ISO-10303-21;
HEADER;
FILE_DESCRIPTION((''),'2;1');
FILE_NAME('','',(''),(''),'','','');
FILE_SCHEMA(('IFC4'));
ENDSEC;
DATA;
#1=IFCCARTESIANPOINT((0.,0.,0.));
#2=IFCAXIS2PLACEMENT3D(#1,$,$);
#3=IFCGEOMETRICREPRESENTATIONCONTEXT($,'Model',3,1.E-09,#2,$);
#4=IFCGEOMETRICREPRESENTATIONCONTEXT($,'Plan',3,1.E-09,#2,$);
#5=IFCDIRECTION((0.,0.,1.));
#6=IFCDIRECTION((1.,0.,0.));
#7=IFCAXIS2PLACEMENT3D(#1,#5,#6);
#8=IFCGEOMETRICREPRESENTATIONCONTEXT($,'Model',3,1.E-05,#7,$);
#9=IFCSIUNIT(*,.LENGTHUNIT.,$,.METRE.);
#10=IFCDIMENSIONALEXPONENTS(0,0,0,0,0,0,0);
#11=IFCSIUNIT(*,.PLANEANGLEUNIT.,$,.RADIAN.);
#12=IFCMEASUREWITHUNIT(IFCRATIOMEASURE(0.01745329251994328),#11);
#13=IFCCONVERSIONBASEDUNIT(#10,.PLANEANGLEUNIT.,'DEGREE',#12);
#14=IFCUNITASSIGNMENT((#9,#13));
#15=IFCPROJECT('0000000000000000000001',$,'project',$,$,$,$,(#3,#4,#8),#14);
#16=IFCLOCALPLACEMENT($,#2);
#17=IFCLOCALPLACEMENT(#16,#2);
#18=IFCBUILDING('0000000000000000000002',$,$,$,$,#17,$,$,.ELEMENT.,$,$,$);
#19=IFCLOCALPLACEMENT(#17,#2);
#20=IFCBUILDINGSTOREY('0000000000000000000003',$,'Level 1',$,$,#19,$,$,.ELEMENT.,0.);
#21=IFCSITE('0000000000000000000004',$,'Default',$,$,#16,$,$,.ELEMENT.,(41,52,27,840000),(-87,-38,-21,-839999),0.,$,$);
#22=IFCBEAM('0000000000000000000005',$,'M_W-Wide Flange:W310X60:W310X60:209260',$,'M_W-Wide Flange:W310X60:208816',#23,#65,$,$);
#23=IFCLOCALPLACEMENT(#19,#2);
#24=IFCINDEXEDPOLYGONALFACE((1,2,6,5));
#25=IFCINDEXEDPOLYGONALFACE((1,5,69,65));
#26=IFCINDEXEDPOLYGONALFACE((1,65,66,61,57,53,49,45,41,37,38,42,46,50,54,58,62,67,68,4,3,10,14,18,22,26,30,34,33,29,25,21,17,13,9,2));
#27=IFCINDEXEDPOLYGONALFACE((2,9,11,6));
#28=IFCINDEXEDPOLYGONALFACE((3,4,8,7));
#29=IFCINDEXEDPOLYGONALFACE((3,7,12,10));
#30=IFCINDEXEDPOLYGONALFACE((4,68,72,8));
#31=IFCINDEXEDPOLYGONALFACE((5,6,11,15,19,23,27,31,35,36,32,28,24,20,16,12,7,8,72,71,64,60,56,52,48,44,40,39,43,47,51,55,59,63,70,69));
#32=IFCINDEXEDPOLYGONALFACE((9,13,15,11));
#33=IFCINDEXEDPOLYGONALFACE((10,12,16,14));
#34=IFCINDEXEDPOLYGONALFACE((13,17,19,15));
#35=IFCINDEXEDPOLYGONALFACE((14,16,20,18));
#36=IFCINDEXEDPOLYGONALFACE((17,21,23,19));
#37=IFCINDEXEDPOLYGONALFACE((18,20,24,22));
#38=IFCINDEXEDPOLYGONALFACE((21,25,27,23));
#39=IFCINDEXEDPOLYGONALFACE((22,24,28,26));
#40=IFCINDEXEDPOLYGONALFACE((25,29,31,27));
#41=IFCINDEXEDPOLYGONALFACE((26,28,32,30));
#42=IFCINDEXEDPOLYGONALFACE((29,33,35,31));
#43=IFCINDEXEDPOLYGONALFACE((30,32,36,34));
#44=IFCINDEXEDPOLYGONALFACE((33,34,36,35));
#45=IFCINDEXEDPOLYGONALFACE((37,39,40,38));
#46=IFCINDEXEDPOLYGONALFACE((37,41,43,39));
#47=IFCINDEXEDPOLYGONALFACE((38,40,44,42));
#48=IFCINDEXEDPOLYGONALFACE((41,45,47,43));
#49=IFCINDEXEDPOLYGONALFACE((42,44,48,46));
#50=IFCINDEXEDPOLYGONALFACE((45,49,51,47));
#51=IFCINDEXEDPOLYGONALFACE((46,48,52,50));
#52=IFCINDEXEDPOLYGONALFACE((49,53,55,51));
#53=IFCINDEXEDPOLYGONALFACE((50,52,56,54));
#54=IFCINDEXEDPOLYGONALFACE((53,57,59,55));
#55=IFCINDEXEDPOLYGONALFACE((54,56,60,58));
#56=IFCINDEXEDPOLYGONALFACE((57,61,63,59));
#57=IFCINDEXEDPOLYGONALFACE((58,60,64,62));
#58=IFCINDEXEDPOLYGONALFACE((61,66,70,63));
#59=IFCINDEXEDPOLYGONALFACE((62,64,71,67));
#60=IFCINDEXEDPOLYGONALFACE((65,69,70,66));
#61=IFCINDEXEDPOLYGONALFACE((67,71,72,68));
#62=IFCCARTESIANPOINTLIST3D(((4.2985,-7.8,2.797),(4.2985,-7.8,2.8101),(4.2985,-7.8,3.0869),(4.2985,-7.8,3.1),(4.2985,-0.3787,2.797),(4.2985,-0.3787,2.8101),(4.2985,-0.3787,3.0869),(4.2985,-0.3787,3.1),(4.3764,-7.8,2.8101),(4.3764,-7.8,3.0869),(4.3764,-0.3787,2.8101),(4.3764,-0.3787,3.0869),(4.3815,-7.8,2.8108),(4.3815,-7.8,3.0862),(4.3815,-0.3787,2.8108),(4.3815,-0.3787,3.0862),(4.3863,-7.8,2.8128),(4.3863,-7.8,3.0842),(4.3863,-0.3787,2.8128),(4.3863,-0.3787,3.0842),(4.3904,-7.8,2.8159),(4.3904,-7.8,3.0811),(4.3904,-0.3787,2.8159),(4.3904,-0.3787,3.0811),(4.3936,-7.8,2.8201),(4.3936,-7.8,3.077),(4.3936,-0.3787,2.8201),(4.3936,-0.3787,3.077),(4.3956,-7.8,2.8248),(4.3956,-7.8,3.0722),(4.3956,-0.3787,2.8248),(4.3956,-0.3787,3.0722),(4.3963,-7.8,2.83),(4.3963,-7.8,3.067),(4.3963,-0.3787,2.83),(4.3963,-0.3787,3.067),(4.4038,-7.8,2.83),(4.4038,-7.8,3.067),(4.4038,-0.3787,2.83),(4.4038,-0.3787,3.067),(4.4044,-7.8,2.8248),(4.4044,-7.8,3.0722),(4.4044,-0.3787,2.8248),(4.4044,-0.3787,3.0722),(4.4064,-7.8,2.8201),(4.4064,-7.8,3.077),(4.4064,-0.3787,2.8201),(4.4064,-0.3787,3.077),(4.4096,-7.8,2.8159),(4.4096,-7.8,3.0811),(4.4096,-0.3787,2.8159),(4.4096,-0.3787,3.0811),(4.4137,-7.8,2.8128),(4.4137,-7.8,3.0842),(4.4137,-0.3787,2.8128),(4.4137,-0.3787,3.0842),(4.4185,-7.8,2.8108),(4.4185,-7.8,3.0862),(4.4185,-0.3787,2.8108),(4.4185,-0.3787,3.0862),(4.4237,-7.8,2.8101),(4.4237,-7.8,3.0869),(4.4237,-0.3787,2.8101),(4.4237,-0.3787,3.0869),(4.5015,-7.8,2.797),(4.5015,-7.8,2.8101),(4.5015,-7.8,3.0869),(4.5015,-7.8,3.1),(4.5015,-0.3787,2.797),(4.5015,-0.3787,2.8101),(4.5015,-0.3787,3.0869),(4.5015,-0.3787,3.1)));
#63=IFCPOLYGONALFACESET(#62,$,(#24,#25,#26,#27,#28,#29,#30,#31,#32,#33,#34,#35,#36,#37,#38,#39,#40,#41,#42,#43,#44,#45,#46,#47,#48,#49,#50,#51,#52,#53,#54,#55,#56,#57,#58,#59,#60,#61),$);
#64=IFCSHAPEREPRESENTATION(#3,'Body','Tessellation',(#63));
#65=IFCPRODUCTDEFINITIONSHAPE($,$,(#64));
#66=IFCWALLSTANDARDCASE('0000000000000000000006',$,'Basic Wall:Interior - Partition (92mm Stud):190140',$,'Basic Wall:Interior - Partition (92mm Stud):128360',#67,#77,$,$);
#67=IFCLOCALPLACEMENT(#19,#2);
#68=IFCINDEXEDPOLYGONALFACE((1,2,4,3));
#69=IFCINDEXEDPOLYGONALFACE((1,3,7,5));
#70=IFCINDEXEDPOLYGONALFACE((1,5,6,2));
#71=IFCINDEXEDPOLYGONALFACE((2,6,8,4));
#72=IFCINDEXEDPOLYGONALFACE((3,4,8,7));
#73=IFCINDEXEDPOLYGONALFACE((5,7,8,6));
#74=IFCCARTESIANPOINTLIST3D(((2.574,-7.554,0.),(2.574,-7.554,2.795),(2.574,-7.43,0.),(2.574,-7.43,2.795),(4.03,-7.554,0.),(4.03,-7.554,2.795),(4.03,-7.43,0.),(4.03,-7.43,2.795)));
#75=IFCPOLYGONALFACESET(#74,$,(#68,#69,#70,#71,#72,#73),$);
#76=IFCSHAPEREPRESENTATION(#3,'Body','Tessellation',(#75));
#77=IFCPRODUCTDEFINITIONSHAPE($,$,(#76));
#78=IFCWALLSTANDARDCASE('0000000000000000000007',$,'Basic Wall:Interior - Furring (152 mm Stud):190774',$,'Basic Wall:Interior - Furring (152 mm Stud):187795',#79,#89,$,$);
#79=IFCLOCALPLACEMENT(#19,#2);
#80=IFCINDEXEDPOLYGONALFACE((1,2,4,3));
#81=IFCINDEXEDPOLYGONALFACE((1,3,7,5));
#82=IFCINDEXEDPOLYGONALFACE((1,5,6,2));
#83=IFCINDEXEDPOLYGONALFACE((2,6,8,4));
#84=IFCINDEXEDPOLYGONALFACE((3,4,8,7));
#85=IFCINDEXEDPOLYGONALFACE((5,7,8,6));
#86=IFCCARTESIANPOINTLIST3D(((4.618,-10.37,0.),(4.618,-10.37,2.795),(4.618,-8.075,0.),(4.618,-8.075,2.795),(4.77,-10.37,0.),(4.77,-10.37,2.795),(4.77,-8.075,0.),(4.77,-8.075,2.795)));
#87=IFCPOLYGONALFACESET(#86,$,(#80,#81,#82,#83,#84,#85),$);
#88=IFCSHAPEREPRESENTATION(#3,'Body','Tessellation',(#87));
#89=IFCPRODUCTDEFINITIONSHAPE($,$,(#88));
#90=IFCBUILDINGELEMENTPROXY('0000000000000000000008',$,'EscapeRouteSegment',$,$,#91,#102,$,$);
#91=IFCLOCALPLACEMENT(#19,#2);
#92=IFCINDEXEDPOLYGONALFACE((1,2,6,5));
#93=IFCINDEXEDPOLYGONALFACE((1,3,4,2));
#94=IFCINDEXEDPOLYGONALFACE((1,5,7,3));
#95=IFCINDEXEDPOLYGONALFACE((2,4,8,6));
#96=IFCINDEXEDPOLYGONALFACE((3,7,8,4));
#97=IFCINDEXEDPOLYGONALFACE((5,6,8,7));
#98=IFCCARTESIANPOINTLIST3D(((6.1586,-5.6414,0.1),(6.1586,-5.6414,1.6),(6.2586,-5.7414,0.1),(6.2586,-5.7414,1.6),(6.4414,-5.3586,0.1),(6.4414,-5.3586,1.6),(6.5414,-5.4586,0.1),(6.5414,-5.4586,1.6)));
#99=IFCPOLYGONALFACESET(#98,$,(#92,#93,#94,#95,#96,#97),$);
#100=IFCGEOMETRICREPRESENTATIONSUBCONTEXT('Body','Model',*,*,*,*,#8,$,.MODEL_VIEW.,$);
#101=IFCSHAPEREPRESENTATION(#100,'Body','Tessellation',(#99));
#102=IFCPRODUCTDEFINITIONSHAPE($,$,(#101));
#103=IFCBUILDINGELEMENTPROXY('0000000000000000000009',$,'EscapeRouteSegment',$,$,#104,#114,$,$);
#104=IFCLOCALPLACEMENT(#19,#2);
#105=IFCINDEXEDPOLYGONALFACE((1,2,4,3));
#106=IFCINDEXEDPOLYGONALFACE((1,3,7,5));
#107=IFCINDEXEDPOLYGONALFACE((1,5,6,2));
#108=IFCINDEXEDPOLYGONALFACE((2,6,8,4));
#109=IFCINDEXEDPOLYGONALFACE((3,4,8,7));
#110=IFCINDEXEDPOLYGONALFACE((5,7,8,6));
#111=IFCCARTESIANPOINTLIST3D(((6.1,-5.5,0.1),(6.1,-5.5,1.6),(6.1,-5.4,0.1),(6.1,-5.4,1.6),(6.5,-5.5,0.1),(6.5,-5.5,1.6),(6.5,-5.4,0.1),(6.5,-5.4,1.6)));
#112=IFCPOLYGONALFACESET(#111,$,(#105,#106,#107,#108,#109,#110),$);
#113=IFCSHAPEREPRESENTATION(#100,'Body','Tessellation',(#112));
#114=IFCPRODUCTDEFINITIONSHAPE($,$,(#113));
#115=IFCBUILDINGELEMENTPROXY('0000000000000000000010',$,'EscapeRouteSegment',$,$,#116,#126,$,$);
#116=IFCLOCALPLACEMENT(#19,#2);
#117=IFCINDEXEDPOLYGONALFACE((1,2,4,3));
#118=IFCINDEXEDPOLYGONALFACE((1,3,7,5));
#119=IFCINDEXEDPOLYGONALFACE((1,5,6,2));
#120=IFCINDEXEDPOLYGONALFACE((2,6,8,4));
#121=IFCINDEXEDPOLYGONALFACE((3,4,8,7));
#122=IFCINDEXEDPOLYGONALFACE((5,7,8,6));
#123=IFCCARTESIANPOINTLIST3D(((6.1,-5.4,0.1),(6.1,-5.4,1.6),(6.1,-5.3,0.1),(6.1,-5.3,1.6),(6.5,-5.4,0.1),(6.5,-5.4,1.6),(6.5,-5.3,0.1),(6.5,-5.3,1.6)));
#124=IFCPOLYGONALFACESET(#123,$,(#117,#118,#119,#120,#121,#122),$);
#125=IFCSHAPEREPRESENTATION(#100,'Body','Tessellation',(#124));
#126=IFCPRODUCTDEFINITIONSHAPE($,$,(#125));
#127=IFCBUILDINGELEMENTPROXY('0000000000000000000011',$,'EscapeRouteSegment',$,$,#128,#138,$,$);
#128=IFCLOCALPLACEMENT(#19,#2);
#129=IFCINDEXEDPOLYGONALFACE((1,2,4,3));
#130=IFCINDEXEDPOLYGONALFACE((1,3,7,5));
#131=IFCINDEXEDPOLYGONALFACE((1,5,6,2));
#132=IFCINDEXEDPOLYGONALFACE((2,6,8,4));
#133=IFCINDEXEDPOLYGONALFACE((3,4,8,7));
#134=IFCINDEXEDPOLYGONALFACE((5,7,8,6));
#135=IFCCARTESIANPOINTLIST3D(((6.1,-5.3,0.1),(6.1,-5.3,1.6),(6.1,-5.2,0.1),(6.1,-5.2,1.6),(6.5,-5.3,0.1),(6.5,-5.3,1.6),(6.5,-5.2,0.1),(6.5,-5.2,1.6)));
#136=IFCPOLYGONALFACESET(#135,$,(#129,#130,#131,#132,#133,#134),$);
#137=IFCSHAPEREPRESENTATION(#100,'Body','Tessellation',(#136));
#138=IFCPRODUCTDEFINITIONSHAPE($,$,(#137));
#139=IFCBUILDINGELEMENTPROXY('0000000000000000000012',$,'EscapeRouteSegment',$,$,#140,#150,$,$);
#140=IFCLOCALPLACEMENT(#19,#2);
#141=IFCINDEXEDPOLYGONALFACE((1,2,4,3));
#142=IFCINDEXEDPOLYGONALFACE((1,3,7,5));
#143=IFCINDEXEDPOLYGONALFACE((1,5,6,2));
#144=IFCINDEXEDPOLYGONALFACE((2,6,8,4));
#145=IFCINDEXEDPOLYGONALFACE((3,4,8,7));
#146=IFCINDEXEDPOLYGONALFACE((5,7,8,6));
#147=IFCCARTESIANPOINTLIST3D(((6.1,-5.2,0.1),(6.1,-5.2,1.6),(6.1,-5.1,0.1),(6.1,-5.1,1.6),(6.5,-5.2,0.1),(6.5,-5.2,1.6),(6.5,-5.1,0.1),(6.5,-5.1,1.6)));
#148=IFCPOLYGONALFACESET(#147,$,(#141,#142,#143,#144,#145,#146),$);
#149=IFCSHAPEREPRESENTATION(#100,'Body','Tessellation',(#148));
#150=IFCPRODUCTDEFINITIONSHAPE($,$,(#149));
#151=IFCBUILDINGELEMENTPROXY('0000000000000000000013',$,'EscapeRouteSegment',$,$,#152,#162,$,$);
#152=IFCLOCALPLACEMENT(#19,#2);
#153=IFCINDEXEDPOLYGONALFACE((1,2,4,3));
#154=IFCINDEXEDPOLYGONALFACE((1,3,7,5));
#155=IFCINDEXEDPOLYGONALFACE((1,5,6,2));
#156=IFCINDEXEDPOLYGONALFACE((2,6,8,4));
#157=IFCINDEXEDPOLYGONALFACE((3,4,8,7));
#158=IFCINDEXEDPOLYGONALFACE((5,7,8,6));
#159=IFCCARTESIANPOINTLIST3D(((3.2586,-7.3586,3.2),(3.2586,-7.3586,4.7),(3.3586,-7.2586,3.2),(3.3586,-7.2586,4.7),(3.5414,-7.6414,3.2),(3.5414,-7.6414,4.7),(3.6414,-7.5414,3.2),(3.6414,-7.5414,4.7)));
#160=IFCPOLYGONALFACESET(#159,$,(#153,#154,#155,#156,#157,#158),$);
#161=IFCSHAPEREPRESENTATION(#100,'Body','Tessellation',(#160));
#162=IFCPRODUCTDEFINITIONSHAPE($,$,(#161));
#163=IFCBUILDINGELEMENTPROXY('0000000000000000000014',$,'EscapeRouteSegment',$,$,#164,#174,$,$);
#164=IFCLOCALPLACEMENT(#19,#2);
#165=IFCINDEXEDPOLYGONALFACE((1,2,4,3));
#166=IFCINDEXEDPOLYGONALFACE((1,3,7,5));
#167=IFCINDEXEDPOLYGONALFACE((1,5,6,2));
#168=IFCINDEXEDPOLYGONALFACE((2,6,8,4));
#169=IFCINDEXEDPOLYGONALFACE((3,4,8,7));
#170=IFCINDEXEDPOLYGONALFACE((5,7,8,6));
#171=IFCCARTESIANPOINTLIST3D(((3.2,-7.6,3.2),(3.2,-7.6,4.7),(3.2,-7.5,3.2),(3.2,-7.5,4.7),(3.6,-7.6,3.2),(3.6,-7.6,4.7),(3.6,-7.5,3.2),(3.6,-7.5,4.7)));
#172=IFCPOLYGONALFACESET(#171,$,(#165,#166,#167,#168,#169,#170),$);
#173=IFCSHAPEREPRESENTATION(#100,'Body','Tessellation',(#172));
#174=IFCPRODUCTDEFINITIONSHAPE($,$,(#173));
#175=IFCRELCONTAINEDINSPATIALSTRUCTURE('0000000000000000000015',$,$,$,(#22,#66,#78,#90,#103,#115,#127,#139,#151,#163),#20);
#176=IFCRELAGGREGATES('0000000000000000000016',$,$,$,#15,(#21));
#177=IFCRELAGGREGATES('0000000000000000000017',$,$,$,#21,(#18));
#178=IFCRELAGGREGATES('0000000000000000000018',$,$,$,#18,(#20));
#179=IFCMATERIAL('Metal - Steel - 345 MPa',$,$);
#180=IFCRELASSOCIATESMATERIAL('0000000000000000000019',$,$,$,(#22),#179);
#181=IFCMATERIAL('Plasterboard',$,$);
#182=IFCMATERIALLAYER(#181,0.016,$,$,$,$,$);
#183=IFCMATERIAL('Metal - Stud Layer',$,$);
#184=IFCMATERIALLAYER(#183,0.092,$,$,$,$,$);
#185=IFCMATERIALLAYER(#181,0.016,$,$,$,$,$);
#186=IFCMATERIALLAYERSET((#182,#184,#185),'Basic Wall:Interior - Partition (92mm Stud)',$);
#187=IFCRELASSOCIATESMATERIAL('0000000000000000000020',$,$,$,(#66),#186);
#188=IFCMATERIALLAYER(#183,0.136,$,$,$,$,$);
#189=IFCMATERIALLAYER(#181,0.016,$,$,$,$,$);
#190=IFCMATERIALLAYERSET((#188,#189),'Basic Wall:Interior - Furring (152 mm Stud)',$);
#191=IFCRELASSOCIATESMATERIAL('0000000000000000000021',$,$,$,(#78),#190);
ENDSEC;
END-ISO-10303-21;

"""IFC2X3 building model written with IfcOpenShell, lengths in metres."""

from ifc_helpers import new_model, entity, si_unit, converted_unit, frame, frame_2d, origin, origin_with_axes, place, context, subcontext, project, spatial, polyline, circle_curve, parameter, trimmed, segment, composite_curve, rectangle, outline, extrude, material, layer, layer_set, layer_usage, element, save


model = new_model("IFC2X3")

# Units and contexts
model_context_1 = context("Model", 3, precision=1e-09, world=origin())
plan_context = context("Plan", 3, precision=1e-09, world=origin())
model_context_2 = context("Model", 3, precision=1e-05, world=origin_with_axes())
body_context = subcontext(model_context_2, "Body", "Model", "MODEL_VIEW")
ifc_project = project(units=[si_unit("LENGTHUNIT", "METRE"), converted_unit("PLANEANGLEUNIT", "DEGREE", entity("IfcRatioMeasure", 0.01745329251994328), si_unit("PLANEANGLEUNIT", "RADIAN"), dimensions=[0, 0, 0, 0, 0, 0, 0])], contexts=[model_context_1, plan_context, model_context_2])

# Site, building, storey
site_placement = place(None, origin())
site = spatial("IfcSite", under=ifc_project, at=site_placement, Name="Default", CompositionType="ELEMENT", RefLatitude=(41, 52, 27, 840000), RefLongitude=(-87, -38, -21, -839999), RefElevation=0.0)
building_placement = place(site_placement, origin())
building = spatial("IfcBuilding", under=site, at=building_placement, CompositionType="ELEMENT")
storey_placement = place(building_placement, origin())
storey = spatial("IfcBuildingStorey", under=building, at=storey_placement, Name="Level 1", CompositionType="ELEMENT", Elevation=0.0)

# Beam
ifc_material_1 = material(Name="Metal - Steel - 345 MPa")
beam_placement = place(storey_placement, frame((4.4, -7.8, 3.1)))
element("IfcBeam", 1, at=beam_placement, inside=storey, material=ifc_material_1, Name="M_W-Wide Flange:W310X60:W310X60:209260", ObjectType="M_W-Wide Flange:W310X60:208816", context=model_context_1, shape_type="SweptSolid", body=[
    extrude(outline(composite_curve([segment(polyline([(-0.1015, -0.1384), (-0.1015, -0.1515)]), True, "CONTINUOUS"), segment(polyline([(-0.1015, -0.1515), (0.1015, -0.1515)]), True, "CONTINUOUS"), segment(polyline([(0.1015, -0.1515), (0.1015, -0.1384)]), True, "CONTINUOUS"), segment(polyline([(0.1015, -0.1384), (0.0236, -0.1384)]), True, "CONTINUOUS"), segment(trimmed(circle_curve(frame_2d((0.0236, -0.1185), x_axis=(1.0, 0.0)), 0.0199), [parameter(180.0)], [parameter(270.0)], True, "PARAMETER"), False, "CONTINUOUS"), segment(polyline([(0.0037, -0.1185), (0.0037, 0.1185)]), True, "CONTINUOUS"), segment(trimmed(circle_curve(frame_2d((0.0236, 0.1185), x_axis=(1.0, 0.0)), 0.0199), [parameter(90.0)], [parameter(180.0)], True, "PARAMETER"), False, "CONTINUOUS"), segment(polyline([(0.0236, 0.1384), (0.1015, 0.1384)]), True, "CONTINUOUS"), segment(polyline([(0.1015, 0.1384), (0.1015, 0.1515)]), True, "CONTINUOUS"), segment(polyline([(0.1015, 0.1515), (-0.1015, 0.1515)]), True, "CONTINUOUS"), segment(polyline([(-0.1015, 0.1515), (-0.1015, 0.1384)]), True, "CONTINUOUS"), segment(polyline([(-0.1015, 0.1384), (-0.0237, 0.1384)]), True, "CONTINUOUS"), segment(trimmed(circle_curve(frame_2d((-0.0237, 0.1185), x_axis=(1.0, 0.0)), 0.0199), [parameter(360.0)], [parameter(90.0)], True, "PARAMETER"), False, "CONTINUOUS"), segment(polyline([(-0.0038, 0.1185), (-0.0038, -0.1185)]), True, "CONTINUOUS"), segment(trimmed(circle_curve(frame_2d((-0.0237, -0.1185), x_axis=(1.0, 0.0)), 0.0199), [parameter(270.0)], [parameter(0.0)], True, "PARAMETER"), False, "CONTINUOUS"), segment(polyline([(-0.0237, -0.1384), (-0.1015, -0.1384)]), True, "CONTINUOUS")], self_intersect=False)), frame((0.0, 0.0, -0.1515), z_axis=(0.0, -1.0, 0.0), x_axis=(1.0, 0.0, 0.0)), (0.0, 0.0, -1.0), 7.4213),
])

# Walls
ifc_material_2 = material(Name="Plasterboard")
ifc_layer_1 = layer(ifc_material_2, 0.016)
ifc_material_3 = material(Name="Metal - Stud Layer")
ifc_layer_2 = layer(ifc_material_3, 0.092)
ifc_layer_3 = layer(ifc_material_2, 0.016)
ifc_layer_set_1 = layer_set([ifc_layer_1, ifc_layer_2, ifc_layer_3], Name="Basic Wall:Interior - Partition (92mm Stud)")
ifc_layer_usage_1 = layer_usage(ifc_layer_set_1, "AXIS2", "NEGATIVE", 0.062)
wall_1_placement = place(storey_placement, frame((4.03, -7.492, 0.0), z_axis=(0.0, 0.0, 1.0), x_axis=(-1.0, 0.0, 0.0)))
element("IfcWallStandardCase", 2, at=wall_1_placement, inside=storey, material=ifc_layer_usage_1, Name="Basic Wall:Interior - Partition (92mm Stud):190140", ObjectType="Basic Wall:Interior - Partition (92mm Stud):128360", context=model_context_1, shape_type="SweptSolid", body=[
    extrude(rectangle(XDim=1.456, YDim=0.124, at=frame_2d((0.728, 0.0), x_axis=(-1.0, 0.0))), origin(), (0.0, 0.0, 1.0), 2.795),
])
ifc_layer_4 = layer(ifc_material_3, 0.136)
ifc_layer_5 = layer(ifc_material_2, 0.016)
ifc_layer_set_2 = layer_set([ifc_layer_4, ifc_layer_5], Name="Basic Wall:Interior - Furring (152 mm Stud)")
ifc_layer_usage_2 = layer_usage(ifc_layer_set_2, "AXIS2", "POSITIVE", -0.076)
wall_2_placement = place(storey_placement, frame((4.694, -8.075, 0.0), z_axis=(0.0, 0.0, 1.0), x_axis=(0.0, -1.0, 0.0)))
element("IfcWallStandardCase", 3, at=wall_2_placement, inside=storey, material=ifc_layer_usage_2, Name="Basic Wall:Interior - Furring (152 mm Stud):190774", ObjectType="Basic Wall:Interior - Furring (152 mm Stud):187795", context=model_context_1, shape_type="SweptSolid", body=[
    extrude(rectangle(XDim=2.295, YDim=0.152, at=frame_2d((1.1475, 0.0), x_axis=(-1.0, 0.0))), origin(), (0.0, 0.0, 1.0), 2.795),
])

# Building element proxies
proxy_1_placement = place(storey_placement, frame((6.4, -5.6, 0.1), z_axis=(0.0, 0.0, 1.0), x_axis=(-0.707107, 0.707107, 0.0)))
element("IfcBuildingElementProxy", 4, at=proxy_1_placement, inside=storey, Name="EscapeRouteSegment", context=body_context, shape_type="SweptSolid", body=[
    extrude(outline(polyline([(0.0, -0.2), (0.0, 0.2), (0.1414, 0.2), (0.1414, -0.2), (0.0, -0.2)])), origin_with_axes(), (0.0, 0.0, 1.0), 1.5),
])
for number, where, z_axis, x_axis, name in (
    (5, (6.3, -5.5, 0.1), (0.0, 0.0, 1.0), (0.0, 1.0, 0.0), "EscapeRouteSegment"),
    (6, (6.3, -5.4, 0.1), (0.0, 0.0, 1.0), (0.0, 1.0, 0.0), "EscapeRouteSegment"),
):
    element("IfcBuildingElementProxy", number, at=place(storey_placement, frame(where, z_axis=z_axis, x_axis=x_axis)), inside=storey, Name=name, context=body_context, shape_type="SweptSolid", body=[
        extrude(outline(polyline([(0.0, -0.2), (0.0, 0.2), (0.1, 0.2), (0.1, -0.2), (0.0, -0.2)])), origin_with_axes(), (0.0, 0.0, 1.0), 1.5),
    ])
proxy_2_placement = place(storey_placement, frame((6.3, -5.3, 0.1), z_axis=(0.0, 0.0, 1.0), x_axis=(0.0, 1.0, 0.0)))
element("IfcBuildingElementProxy", 7, at=proxy_2_placement, inside=storey, Name="EscapeRouteSegment", context=body_context, shape_type="SweptSolid", body=[
    extrude(outline(polyline([(0.0, -0.2), (0.0, 0.2), (0.1, 0.2), (0.1, -0.2), (0.0, -0.2)])), origin_with_axes(), (0.0, 0.0, 1.0), 1.5),
])
proxy_3_placement = place(storey_placement, frame((6.3, -5.2, 0.1), z_axis=(0.0, 0.0, 1.0), x_axis=(0.0, 1.0, 0.0)))
element("IfcBuildingElementProxy", 8, at=proxy_3_placement, inside=storey, Name="EscapeRouteSegment", context=body_context, shape_type="SweptSolid", body=[
    extrude(outline(polyline([(0.0, -0.2), (0.0, 0.2), (0.1, 0.2), (0.1, -0.2), (0.0, -0.2)])), origin_with_axes(), (0.0, 0.0, 1.0), 1.5),
])
proxy_4_placement = place(storey_placement, frame((3.5, -7.4, 3.2), z_axis=(0.0, 0.0, 1.0), x_axis=(-0.707107, -0.707107, 0.0)))
element("IfcBuildingElementProxy", 9, at=proxy_4_placement, inside=storey, Name="EscapeRouteSegment", context=body_context, shape_type="SweptSolid", body=[
    extrude(outline(polyline([(0.0, -0.2), (0.0, 0.2), (0.1414, 0.2), (0.1414, -0.2), (0.0, -0.2)])), origin_with_axes(), (0.0, 0.0, 1.0), 1.5),
])
proxy_5_placement = place(storey_placement, frame((3.4, -7.5, 3.2), z_axis=(0.0, 0.0, 1.0), x_axis=(0.0, -1.0, 0.0)))
element("IfcBuildingElementProxy", 10, at=proxy_5_placement, inside=storey, Name="EscapeRouteSegment", context=body_context, shape_type="SweptSolid", body=[
    extrude(outline(polyline([(0.0, -0.2), (0.0, 0.2), (0.1, 0.2), (0.1, -0.2), (0.0, -0.2)])), origin_with_axes(), (0.0, 0.0, 1.0), 1.5),
])

save(model, "model.ifc")
